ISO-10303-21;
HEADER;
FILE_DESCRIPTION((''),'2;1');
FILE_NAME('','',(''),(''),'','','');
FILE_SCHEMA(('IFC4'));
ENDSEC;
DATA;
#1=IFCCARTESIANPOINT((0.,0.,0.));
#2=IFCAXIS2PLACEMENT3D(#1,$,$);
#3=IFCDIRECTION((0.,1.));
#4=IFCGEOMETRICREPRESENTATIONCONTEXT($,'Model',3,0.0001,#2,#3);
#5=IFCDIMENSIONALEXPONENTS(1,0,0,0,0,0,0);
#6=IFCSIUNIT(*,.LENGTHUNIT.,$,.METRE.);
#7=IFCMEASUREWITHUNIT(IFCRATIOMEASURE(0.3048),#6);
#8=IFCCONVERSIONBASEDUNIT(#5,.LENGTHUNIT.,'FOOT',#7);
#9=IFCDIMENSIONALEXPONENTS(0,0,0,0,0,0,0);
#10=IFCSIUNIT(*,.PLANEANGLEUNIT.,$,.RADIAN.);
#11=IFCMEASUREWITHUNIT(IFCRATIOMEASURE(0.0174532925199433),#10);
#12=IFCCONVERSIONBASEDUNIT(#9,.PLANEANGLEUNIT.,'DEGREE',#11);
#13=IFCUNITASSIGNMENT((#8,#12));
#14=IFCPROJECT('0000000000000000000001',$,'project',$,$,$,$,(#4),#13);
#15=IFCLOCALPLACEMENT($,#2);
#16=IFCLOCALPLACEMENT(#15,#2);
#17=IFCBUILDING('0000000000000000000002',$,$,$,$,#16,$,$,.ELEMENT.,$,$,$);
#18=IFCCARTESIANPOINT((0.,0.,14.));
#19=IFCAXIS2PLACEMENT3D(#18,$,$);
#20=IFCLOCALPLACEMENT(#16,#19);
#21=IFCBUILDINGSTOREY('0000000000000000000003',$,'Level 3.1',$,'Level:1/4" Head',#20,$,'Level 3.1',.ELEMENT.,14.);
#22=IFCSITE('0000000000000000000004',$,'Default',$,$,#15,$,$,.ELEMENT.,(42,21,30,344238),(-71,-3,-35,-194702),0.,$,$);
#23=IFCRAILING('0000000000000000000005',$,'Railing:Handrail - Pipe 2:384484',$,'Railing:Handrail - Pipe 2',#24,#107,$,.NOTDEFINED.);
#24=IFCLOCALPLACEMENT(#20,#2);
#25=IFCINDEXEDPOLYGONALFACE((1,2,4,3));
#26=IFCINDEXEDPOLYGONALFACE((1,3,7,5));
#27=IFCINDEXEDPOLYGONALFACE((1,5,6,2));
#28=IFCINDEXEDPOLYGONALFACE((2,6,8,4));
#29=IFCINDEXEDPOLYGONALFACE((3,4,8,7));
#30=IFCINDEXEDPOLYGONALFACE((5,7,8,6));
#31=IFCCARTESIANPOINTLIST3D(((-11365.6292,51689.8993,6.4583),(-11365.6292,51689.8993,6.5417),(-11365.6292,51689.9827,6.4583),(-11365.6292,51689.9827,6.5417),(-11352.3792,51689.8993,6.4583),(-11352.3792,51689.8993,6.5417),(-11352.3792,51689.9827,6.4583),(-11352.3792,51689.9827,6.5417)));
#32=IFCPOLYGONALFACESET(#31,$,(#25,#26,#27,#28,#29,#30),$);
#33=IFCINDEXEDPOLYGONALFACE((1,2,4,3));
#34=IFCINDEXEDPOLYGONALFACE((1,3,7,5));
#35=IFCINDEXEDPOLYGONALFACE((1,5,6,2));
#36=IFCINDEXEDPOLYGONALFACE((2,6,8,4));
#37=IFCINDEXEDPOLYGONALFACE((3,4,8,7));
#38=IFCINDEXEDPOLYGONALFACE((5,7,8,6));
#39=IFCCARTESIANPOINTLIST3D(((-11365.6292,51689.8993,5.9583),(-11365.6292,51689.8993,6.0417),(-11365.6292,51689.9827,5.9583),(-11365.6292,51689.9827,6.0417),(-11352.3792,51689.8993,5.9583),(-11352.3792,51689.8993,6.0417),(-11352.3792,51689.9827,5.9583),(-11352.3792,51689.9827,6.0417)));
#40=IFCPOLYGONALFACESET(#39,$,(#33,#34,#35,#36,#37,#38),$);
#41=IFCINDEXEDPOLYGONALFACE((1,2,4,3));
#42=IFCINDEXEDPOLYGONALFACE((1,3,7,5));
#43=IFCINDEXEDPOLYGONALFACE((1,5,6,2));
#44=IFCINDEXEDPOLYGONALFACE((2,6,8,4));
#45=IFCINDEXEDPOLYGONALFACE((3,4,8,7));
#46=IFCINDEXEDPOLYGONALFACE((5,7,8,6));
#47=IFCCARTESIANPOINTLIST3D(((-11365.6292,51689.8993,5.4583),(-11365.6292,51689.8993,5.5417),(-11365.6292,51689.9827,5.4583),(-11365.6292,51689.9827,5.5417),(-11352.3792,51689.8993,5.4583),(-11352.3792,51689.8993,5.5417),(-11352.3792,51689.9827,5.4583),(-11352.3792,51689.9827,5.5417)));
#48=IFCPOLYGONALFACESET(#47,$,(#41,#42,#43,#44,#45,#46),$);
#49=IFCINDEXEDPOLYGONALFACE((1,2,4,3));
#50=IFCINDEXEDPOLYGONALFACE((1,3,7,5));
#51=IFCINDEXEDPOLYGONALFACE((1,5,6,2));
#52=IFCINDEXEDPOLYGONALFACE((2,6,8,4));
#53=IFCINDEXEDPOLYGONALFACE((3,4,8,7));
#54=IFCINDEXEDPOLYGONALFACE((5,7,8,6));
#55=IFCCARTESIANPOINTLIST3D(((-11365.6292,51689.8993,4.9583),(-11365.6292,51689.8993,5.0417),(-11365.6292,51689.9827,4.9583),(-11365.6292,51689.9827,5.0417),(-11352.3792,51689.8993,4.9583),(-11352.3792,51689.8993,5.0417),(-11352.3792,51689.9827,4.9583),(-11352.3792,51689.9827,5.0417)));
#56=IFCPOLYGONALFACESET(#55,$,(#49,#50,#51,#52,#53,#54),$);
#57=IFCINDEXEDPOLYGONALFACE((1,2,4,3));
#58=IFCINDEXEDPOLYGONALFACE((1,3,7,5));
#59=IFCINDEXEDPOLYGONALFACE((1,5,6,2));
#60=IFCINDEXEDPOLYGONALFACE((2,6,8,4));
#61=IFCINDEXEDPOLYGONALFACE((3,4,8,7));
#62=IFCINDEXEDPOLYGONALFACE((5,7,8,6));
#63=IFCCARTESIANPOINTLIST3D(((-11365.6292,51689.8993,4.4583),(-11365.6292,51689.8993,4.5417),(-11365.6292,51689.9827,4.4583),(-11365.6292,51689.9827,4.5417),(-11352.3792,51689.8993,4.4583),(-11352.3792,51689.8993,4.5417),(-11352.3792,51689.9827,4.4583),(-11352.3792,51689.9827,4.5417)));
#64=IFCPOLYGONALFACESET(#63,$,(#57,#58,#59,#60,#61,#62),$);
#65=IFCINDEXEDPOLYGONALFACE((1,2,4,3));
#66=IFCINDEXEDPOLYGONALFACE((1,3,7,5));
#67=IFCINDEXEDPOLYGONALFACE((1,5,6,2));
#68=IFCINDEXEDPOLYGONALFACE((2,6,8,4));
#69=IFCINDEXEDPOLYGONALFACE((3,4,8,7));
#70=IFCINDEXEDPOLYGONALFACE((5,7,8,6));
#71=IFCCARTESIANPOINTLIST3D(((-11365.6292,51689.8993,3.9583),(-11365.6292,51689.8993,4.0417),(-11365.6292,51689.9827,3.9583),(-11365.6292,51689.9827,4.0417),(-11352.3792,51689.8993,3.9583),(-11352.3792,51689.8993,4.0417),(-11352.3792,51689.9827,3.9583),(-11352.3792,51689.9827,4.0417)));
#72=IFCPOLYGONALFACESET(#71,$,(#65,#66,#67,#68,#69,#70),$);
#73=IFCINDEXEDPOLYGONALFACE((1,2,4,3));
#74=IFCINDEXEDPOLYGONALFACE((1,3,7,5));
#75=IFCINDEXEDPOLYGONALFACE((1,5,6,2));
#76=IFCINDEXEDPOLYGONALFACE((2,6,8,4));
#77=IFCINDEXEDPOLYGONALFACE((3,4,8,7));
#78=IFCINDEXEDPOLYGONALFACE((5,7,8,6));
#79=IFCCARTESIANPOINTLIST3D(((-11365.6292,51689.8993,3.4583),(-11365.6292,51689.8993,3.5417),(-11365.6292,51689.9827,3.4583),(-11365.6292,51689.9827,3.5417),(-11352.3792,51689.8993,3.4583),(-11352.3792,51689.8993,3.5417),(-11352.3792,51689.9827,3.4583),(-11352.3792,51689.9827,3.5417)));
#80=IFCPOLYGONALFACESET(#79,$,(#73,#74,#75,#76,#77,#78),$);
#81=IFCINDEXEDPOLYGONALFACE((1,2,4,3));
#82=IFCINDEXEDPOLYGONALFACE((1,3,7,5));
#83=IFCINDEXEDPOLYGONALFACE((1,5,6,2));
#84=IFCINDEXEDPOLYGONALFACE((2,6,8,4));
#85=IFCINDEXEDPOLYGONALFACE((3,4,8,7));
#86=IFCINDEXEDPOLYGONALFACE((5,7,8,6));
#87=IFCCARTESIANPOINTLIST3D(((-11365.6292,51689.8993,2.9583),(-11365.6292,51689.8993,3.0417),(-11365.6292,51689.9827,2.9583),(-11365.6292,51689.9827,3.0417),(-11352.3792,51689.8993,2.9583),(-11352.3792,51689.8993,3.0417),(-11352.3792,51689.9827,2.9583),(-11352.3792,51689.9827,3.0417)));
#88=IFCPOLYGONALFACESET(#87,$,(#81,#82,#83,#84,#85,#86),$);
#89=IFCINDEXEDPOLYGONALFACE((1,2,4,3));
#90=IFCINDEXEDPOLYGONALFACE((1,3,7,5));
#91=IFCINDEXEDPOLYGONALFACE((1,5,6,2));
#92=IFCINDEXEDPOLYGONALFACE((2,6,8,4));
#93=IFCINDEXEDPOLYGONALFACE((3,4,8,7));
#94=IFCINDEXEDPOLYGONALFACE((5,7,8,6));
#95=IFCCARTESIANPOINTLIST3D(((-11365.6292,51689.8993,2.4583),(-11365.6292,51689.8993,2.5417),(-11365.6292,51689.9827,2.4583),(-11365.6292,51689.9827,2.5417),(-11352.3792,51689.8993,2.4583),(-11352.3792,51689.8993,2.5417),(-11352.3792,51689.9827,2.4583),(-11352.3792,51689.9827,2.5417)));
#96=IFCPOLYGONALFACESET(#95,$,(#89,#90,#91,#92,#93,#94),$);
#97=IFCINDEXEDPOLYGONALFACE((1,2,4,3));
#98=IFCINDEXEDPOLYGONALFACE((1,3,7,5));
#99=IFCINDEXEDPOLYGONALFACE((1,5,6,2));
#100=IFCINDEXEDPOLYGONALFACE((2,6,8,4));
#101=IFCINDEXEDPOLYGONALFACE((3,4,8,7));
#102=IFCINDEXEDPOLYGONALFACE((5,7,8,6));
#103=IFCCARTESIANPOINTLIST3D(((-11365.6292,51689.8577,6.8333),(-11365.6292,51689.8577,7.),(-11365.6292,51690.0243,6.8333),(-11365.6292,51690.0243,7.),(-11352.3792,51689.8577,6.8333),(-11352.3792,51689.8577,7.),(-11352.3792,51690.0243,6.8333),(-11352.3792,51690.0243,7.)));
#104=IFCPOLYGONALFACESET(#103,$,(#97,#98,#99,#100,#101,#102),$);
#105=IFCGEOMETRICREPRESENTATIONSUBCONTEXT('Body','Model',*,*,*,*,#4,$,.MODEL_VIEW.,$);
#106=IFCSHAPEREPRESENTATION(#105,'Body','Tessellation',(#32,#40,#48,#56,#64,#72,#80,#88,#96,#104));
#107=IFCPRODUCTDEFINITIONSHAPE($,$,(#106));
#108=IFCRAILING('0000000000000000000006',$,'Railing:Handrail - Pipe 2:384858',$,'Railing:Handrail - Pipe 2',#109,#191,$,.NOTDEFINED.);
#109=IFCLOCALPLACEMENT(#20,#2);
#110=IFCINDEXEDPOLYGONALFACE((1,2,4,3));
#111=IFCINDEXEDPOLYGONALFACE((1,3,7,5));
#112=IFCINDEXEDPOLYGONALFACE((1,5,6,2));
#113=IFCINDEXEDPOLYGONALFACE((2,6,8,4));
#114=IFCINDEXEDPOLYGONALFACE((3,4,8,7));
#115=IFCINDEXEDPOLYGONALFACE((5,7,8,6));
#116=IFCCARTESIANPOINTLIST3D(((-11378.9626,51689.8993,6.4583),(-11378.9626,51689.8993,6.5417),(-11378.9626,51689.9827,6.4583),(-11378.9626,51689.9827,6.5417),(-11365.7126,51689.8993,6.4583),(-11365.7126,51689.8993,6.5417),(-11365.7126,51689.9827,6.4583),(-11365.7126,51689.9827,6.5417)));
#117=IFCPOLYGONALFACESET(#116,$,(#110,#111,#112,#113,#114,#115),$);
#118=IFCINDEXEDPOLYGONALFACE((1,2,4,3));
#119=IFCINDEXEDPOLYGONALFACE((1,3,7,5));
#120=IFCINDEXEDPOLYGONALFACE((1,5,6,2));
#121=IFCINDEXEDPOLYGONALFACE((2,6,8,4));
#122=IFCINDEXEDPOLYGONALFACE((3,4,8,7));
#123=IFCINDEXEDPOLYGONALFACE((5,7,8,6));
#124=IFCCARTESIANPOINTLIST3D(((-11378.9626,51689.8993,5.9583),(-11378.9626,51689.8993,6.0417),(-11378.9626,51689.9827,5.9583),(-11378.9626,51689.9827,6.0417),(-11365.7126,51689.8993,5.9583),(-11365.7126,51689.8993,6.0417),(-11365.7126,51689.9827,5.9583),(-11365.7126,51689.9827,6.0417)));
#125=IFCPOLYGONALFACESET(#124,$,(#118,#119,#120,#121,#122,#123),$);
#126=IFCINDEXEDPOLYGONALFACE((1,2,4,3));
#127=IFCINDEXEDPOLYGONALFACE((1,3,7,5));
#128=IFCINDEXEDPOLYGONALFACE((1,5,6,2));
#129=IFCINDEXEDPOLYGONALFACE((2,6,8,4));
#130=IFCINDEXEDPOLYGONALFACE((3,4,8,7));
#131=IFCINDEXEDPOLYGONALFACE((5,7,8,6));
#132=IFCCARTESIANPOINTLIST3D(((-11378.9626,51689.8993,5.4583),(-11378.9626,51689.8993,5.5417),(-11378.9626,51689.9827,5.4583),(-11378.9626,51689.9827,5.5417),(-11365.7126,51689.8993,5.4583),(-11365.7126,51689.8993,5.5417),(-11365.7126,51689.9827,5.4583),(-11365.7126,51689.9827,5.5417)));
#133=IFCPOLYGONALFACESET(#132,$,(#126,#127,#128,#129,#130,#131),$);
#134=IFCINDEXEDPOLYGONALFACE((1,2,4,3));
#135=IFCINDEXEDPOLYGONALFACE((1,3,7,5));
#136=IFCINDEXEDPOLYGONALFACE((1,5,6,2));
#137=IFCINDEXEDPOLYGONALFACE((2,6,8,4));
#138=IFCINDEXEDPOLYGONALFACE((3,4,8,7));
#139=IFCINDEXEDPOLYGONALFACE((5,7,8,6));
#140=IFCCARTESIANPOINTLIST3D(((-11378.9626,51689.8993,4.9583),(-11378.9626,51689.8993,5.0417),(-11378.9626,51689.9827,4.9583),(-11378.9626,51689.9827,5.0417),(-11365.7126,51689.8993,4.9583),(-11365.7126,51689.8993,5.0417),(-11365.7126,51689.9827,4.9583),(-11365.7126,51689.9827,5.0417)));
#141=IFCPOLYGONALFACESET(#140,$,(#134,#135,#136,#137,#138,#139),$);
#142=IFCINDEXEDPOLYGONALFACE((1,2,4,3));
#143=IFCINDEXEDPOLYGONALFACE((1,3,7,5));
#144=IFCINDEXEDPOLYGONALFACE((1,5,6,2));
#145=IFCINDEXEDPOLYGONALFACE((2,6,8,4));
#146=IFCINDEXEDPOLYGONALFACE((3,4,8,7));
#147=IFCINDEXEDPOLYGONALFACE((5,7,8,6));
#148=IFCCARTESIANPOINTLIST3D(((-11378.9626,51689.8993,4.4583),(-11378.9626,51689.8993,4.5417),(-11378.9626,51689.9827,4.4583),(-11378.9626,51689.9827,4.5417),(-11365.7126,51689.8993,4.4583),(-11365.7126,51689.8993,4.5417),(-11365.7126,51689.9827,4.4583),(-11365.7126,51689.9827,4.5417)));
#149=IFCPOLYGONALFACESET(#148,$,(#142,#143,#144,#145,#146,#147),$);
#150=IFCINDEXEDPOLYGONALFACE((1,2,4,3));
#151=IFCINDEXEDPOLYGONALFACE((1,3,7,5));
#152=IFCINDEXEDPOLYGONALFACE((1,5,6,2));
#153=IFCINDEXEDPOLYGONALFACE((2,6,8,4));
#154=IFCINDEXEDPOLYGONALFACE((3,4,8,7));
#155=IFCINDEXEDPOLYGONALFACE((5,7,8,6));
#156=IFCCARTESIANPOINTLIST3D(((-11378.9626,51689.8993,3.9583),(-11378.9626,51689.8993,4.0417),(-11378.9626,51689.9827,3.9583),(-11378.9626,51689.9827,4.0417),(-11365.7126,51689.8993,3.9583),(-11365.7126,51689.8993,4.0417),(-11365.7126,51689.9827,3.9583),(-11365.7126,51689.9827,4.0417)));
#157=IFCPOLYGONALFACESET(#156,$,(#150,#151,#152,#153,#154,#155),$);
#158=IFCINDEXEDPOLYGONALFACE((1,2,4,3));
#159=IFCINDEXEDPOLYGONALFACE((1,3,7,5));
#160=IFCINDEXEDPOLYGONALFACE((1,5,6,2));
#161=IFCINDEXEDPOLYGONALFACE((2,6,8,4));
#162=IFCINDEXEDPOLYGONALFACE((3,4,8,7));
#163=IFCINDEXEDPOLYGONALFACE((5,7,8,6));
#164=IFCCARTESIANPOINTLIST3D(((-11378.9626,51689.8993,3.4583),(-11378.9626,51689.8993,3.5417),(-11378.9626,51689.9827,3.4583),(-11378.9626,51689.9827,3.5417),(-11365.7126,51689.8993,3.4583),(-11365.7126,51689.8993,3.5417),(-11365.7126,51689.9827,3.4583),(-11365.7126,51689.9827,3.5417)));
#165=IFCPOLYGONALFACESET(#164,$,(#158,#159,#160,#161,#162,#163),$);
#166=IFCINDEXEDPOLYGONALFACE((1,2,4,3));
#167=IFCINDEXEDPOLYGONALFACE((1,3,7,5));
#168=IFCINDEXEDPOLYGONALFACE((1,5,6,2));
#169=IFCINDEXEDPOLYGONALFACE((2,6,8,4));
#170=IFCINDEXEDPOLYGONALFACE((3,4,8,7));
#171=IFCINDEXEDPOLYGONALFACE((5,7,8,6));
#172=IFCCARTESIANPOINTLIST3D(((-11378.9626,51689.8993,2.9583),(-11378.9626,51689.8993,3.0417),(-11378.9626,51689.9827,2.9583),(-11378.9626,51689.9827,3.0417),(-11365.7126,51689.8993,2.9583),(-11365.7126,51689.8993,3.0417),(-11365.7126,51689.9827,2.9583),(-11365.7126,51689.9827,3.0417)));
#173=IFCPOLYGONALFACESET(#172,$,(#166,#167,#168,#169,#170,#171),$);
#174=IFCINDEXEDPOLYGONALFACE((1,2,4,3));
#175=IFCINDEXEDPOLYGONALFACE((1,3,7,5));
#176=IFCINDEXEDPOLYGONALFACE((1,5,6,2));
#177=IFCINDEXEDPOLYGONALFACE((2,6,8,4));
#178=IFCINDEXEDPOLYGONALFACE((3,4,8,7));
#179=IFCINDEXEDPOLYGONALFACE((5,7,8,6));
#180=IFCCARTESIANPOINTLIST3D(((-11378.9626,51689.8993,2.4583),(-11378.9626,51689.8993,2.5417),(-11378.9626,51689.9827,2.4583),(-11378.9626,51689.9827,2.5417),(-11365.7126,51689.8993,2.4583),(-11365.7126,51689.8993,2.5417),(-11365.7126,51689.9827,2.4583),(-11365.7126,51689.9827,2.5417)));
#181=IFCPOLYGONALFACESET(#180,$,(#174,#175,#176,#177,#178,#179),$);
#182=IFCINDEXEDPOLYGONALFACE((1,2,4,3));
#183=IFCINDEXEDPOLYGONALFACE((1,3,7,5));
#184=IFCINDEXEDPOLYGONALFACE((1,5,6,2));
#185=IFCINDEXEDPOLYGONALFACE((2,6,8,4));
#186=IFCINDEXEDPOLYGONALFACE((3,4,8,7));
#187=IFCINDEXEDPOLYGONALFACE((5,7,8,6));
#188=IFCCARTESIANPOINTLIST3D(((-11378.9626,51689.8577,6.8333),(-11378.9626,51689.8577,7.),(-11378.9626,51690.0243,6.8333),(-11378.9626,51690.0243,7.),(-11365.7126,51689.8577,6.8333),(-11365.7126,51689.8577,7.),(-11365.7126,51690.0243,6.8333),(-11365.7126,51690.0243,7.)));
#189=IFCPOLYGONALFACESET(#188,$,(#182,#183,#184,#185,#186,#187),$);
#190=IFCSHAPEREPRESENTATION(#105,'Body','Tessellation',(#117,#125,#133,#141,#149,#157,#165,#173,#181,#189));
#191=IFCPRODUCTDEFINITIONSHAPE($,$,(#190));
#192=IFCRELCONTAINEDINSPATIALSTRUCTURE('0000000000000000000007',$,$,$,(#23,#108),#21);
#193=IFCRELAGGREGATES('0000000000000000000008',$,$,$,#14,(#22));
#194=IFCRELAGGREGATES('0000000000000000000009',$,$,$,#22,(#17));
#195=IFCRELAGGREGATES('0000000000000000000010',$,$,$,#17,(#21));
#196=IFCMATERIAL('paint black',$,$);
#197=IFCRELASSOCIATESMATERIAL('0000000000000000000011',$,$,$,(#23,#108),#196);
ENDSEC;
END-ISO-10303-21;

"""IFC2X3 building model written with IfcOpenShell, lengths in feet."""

from ifc_helpers import new_model, entity, si_unit, converted_unit, direction, frame, frame_2d, origin, place, context, subcontext, project, spatial, rectangle, extrude, material, element, save


model = new_model("IFC2X3")

# Units and contexts
model_context = context("Model", 3, precision=0.0001, world=origin(), true_north=direction((0.0, 1.0)))
body_context = subcontext(model_context, "Body", "Model", "MODEL_VIEW")
ifc_project = project(units=[converted_unit("LENGTHUNIT", "FOOT", entity("IfcRatioMeasure", 0.3048), si_unit("LENGTHUNIT", "METRE"), dimensions=[1, 0, 0, 0, 0, 0, 0]), converted_unit("PLANEANGLEUNIT", "DEGREE", entity("IfcRatioMeasure", 0.0174532925199433), si_unit("PLANEANGLEUNIT", "RADIAN"), dimensions=[0, 0, 0, 0, 0, 0, 0])], contexts=[model_context])

# Site, building, storey
site_placement = place(None, origin())
site = spatial("IfcSite", under=ifc_project, at=site_placement, Name="Default", CompositionType="ELEMENT", RefLatitude=(42, 21, 30, 344238), RefLongitude=(-71, -3, -35, -194702), RefElevation=0.0)
building_placement = place(site_placement, origin())
building = spatial("IfcBuilding", under=site, at=building_placement, CompositionType="ELEMENT")
storey_placement = place(building_placement, frame((0.0, 0.0, 14.0)))
storey = spatial("IfcBuildingStorey", under=building, at=storey_placement, Name="Level 3.1", ObjectType="Level:1/4\" Head", LongName="Level 3.1", CompositionType="ELEMENT", Elevation=14.0)

# Railings
ifc_material_1 = material(Name="paint black")
railing_1_placement = place(storey_placement, origin())
element("IfcRailing", 1, at=railing_1_placement, inside=storey, material=ifc_material_1, Name="Railing:Handrail - Pipe 2:384484", ObjectType="Railing:Handrail - Pipe 2", PredefinedType="NOTDEFINED", context=body_context, shape_type="SweptSolid", body=[
    extrude(rectangle(XDim=13.25, YDim=0.0833, at=frame_2d((0.0, 0.0), x_axis=(1.0, 0.0))), frame((-11359.0042, 51689.941, 6.4583), z_axis=(0.0, 0.0, 1.0), x_axis=(-1.0, 0.0, 0.0)), (0.0, 0.0, 1.0), 0.0833),
    extrude(rectangle(XDim=13.25, YDim=0.0833, at=frame_2d((0.0, 0.0), x_axis=(1.0, 0.0))), frame((-11359.0042, 51689.941, 5.9583), z_axis=(0.0, 0.0, 1.0), x_axis=(-1.0, 0.0, 0.0)), (0.0, 0.0, 1.0), 0.0833),
    extrude(rectangle(XDim=13.25, YDim=0.0833, at=frame_2d((0.0, 0.0), x_axis=(1.0, 0.0))), frame((-11359.0042, 51689.941, 5.4583), z_axis=(0.0, 0.0, 1.0), x_axis=(-1.0, 0.0, 0.0)), (0.0, 0.0, 1.0), 0.0833),
    extrude(rectangle(XDim=13.25, YDim=0.0833, at=frame_2d((0.0, 0.0), x_axis=(1.0, 0.0))), frame((-11359.0042, 51689.941, 4.9583), z_axis=(0.0, 0.0, 1.0), x_axis=(-1.0, 0.0, 0.0)), (0.0, 0.0, 1.0), 0.0833),
    extrude(rectangle(XDim=13.25, YDim=0.0833, at=frame_2d((0.0, 0.0), x_axis=(1.0, 0.0))), frame((-11359.0042, 51689.941, 4.4583), z_axis=(0.0, 0.0, 1.0), x_axis=(-1.0, 0.0, 0.0)), (0.0, 0.0, 1.0), 0.0833),
    extrude(rectangle(XDim=13.25, YDim=0.0833, at=frame_2d((0.0, 0.0), x_axis=(1.0, 0.0))), frame((-11359.0042, 51689.941, 3.9583), z_axis=(0.0, 0.0, 1.0), x_axis=(-1.0, 0.0, 0.0)), (0.0, 0.0, 1.0), 0.0833),
    extrude(rectangle(XDim=13.25, YDim=0.0833, at=frame_2d((0.0, 0.0), x_axis=(1.0, 0.0))), frame((-11359.0042, 51689.941, 3.4583), z_axis=(0.0, 0.0, 1.0), x_axis=(-1.0, 0.0, 0.0)), (0.0, 0.0, 1.0), 0.0833),
    extrude(rectangle(XDim=13.25, YDim=0.0833, at=frame_2d((0.0, 0.0), x_axis=(1.0, 0.0))), frame((-11359.0042, 51689.941, 2.9583), z_axis=(0.0, 0.0, 1.0), x_axis=(-1.0, 0.0, 0.0)), (0.0, 0.0, 1.0), 0.0833),
    extrude(rectangle(XDim=13.25, YDim=0.0833, at=frame_2d((0.0, 0.0), x_axis=(1.0, 0.0))), frame((-11359.0042, 51689.941, 2.4583), z_axis=(0.0, 0.0, 1.0), x_axis=(-1.0, 0.0, 0.0)), (0.0, 0.0, 1.0), 0.0833),
    extrude(rectangle(XDim=13.25, YDim=0.1667, at=frame_2d((0.0, 0.0), x_axis=(1.0, 0.0))), frame((-11359.0042, 51689.941, 6.8333), z_axis=(0.0, 0.0, 1.0), x_axis=(-1.0, 0.0, 0.0)), (0.0, 0.0, 1.0), 0.1667),
])
railing_2_placement = place(storey_placement, origin())
element("IfcRailing", 2, at=railing_2_placement, inside=storey, material=ifc_material_1, Name="Railing:Handrail - Pipe 2:384858", ObjectType="Railing:Handrail - Pipe 2", PredefinedType="NOTDEFINED", context=body_context, shape_type="SweptSolid", body=[
    extrude(rectangle(XDim=13.25, YDim=0.0833, at=frame_2d((0.0, 0.0), x_axis=(1.0, 0.0))), frame((-11372.3376, 51689.941, 6.4583), z_axis=(0.0, 0.0, 1.0), x_axis=(-1.0, 0.0, 0.0)), (0.0, 0.0, 1.0), 0.0833),
    extrude(rectangle(XDim=13.25, YDim=0.0833, at=frame_2d((0.0, 0.0), x_axis=(1.0, 0.0))), frame((-11372.3376, 51689.941, 5.9583), z_axis=(0.0, 0.0, 1.0), x_axis=(-1.0, 0.0, 0.0)), (0.0, 0.0, 1.0), 0.0833),
    extrude(rectangle(XDim=13.25, YDim=0.0833, at=frame_2d((0.0, 0.0), x_axis=(1.0, 0.0))), frame((-11372.3376, 51689.941, 5.4583), z_axis=(0.0, 0.0, 1.0), x_axis=(-1.0, 0.0, 0.0)), (0.0, 0.0, 1.0), 0.0833),
    extrude(rectangle(XDim=13.25, YDim=0.0833, at=frame_2d((0.0, 0.0), x_axis=(1.0, 0.0))), frame((-11372.3376, 51689.941, 4.9583), z_axis=(0.0, 0.0, 1.0), x_axis=(-1.0, 0.0, 0.0)), (0.0, 0.0, 1.0), 0.0833),
    extrude(rectangle(XDim=13.25, YDim=0.0833, at=frame_2d((0.0, 0.0), x_axis=(1.0, 0.0))), frame((-11372.3376, 51689.941, 4.4583), z_axis=(0.0, 0.0, 1.0), x_axis=(-1.0, 0.0, 0.0)), (0.0, 0.0, 1.0), 0.0833),
    extrude(rectangle(XDim=13.25, YDim=0.0833, at=frame_2d((0.0, 0.0), x_axis=(1.0, 0.0))), frame((-11372.3376, 51689.941, 3.9583), z_axis=(0.0, 0.0, 1.0), x_axis=(-1.0, 0.0, 0.0)), (0.0, 0.0, 1.0), 0.0833),
    extrude(rectangle(XDim=13.25, YDim=0.0833, at=frame_2d((0.0, 0.0), x_axis=(1.0, 0.0))), frame((-11372.3376, 51689.941, 3.4583), z_axis=(0.0, 0.0, 1.0), x_axis=(-1.0, 0.0, 0.0)), (0.0, 0.0, 1.0), 0.0833),
    extrude(rectangle(XDim=13.25, YDim=0.0833, at=frame_2d((0.0, 0.0), x_axis=(1.0, 0.0))), frame((-11372.3376, 51689.941, 2.9583), z_axis=(0.0, 0.0, 1.0), x_axis=(-1.0, 0.0, 0.0)), (0.0, 0.0, 1.0), 0.0833),
    extrude(rectangle(XDim=13.25, YDim=0.0833, at=frame_2d((0.0, 0.0), x_axis=(1.0, 0.0))), frame((-11372.3376, 51689.941, 2.4583), z_axis=(0.0, 0.0, 1.0), x_axis=(-1.0, 0.0, 0.0)), (0.0, 0.0, 1.0), 0.0833),
    extrude(rectangle(XDim=13.25, YDim=0.1667, at=frame_2d((0.0, 0.0), x_axis=(1.0, 0.0))), frame((-11372.3376, 51689.941, 6.8333), z_axis=(0.0, 0.0, 1.0), x_axis=(-1.0, 0.0, 0.0)), (0.0, 0.0, 1.0), 0.1667),
])

save(model, "model.ifc")
